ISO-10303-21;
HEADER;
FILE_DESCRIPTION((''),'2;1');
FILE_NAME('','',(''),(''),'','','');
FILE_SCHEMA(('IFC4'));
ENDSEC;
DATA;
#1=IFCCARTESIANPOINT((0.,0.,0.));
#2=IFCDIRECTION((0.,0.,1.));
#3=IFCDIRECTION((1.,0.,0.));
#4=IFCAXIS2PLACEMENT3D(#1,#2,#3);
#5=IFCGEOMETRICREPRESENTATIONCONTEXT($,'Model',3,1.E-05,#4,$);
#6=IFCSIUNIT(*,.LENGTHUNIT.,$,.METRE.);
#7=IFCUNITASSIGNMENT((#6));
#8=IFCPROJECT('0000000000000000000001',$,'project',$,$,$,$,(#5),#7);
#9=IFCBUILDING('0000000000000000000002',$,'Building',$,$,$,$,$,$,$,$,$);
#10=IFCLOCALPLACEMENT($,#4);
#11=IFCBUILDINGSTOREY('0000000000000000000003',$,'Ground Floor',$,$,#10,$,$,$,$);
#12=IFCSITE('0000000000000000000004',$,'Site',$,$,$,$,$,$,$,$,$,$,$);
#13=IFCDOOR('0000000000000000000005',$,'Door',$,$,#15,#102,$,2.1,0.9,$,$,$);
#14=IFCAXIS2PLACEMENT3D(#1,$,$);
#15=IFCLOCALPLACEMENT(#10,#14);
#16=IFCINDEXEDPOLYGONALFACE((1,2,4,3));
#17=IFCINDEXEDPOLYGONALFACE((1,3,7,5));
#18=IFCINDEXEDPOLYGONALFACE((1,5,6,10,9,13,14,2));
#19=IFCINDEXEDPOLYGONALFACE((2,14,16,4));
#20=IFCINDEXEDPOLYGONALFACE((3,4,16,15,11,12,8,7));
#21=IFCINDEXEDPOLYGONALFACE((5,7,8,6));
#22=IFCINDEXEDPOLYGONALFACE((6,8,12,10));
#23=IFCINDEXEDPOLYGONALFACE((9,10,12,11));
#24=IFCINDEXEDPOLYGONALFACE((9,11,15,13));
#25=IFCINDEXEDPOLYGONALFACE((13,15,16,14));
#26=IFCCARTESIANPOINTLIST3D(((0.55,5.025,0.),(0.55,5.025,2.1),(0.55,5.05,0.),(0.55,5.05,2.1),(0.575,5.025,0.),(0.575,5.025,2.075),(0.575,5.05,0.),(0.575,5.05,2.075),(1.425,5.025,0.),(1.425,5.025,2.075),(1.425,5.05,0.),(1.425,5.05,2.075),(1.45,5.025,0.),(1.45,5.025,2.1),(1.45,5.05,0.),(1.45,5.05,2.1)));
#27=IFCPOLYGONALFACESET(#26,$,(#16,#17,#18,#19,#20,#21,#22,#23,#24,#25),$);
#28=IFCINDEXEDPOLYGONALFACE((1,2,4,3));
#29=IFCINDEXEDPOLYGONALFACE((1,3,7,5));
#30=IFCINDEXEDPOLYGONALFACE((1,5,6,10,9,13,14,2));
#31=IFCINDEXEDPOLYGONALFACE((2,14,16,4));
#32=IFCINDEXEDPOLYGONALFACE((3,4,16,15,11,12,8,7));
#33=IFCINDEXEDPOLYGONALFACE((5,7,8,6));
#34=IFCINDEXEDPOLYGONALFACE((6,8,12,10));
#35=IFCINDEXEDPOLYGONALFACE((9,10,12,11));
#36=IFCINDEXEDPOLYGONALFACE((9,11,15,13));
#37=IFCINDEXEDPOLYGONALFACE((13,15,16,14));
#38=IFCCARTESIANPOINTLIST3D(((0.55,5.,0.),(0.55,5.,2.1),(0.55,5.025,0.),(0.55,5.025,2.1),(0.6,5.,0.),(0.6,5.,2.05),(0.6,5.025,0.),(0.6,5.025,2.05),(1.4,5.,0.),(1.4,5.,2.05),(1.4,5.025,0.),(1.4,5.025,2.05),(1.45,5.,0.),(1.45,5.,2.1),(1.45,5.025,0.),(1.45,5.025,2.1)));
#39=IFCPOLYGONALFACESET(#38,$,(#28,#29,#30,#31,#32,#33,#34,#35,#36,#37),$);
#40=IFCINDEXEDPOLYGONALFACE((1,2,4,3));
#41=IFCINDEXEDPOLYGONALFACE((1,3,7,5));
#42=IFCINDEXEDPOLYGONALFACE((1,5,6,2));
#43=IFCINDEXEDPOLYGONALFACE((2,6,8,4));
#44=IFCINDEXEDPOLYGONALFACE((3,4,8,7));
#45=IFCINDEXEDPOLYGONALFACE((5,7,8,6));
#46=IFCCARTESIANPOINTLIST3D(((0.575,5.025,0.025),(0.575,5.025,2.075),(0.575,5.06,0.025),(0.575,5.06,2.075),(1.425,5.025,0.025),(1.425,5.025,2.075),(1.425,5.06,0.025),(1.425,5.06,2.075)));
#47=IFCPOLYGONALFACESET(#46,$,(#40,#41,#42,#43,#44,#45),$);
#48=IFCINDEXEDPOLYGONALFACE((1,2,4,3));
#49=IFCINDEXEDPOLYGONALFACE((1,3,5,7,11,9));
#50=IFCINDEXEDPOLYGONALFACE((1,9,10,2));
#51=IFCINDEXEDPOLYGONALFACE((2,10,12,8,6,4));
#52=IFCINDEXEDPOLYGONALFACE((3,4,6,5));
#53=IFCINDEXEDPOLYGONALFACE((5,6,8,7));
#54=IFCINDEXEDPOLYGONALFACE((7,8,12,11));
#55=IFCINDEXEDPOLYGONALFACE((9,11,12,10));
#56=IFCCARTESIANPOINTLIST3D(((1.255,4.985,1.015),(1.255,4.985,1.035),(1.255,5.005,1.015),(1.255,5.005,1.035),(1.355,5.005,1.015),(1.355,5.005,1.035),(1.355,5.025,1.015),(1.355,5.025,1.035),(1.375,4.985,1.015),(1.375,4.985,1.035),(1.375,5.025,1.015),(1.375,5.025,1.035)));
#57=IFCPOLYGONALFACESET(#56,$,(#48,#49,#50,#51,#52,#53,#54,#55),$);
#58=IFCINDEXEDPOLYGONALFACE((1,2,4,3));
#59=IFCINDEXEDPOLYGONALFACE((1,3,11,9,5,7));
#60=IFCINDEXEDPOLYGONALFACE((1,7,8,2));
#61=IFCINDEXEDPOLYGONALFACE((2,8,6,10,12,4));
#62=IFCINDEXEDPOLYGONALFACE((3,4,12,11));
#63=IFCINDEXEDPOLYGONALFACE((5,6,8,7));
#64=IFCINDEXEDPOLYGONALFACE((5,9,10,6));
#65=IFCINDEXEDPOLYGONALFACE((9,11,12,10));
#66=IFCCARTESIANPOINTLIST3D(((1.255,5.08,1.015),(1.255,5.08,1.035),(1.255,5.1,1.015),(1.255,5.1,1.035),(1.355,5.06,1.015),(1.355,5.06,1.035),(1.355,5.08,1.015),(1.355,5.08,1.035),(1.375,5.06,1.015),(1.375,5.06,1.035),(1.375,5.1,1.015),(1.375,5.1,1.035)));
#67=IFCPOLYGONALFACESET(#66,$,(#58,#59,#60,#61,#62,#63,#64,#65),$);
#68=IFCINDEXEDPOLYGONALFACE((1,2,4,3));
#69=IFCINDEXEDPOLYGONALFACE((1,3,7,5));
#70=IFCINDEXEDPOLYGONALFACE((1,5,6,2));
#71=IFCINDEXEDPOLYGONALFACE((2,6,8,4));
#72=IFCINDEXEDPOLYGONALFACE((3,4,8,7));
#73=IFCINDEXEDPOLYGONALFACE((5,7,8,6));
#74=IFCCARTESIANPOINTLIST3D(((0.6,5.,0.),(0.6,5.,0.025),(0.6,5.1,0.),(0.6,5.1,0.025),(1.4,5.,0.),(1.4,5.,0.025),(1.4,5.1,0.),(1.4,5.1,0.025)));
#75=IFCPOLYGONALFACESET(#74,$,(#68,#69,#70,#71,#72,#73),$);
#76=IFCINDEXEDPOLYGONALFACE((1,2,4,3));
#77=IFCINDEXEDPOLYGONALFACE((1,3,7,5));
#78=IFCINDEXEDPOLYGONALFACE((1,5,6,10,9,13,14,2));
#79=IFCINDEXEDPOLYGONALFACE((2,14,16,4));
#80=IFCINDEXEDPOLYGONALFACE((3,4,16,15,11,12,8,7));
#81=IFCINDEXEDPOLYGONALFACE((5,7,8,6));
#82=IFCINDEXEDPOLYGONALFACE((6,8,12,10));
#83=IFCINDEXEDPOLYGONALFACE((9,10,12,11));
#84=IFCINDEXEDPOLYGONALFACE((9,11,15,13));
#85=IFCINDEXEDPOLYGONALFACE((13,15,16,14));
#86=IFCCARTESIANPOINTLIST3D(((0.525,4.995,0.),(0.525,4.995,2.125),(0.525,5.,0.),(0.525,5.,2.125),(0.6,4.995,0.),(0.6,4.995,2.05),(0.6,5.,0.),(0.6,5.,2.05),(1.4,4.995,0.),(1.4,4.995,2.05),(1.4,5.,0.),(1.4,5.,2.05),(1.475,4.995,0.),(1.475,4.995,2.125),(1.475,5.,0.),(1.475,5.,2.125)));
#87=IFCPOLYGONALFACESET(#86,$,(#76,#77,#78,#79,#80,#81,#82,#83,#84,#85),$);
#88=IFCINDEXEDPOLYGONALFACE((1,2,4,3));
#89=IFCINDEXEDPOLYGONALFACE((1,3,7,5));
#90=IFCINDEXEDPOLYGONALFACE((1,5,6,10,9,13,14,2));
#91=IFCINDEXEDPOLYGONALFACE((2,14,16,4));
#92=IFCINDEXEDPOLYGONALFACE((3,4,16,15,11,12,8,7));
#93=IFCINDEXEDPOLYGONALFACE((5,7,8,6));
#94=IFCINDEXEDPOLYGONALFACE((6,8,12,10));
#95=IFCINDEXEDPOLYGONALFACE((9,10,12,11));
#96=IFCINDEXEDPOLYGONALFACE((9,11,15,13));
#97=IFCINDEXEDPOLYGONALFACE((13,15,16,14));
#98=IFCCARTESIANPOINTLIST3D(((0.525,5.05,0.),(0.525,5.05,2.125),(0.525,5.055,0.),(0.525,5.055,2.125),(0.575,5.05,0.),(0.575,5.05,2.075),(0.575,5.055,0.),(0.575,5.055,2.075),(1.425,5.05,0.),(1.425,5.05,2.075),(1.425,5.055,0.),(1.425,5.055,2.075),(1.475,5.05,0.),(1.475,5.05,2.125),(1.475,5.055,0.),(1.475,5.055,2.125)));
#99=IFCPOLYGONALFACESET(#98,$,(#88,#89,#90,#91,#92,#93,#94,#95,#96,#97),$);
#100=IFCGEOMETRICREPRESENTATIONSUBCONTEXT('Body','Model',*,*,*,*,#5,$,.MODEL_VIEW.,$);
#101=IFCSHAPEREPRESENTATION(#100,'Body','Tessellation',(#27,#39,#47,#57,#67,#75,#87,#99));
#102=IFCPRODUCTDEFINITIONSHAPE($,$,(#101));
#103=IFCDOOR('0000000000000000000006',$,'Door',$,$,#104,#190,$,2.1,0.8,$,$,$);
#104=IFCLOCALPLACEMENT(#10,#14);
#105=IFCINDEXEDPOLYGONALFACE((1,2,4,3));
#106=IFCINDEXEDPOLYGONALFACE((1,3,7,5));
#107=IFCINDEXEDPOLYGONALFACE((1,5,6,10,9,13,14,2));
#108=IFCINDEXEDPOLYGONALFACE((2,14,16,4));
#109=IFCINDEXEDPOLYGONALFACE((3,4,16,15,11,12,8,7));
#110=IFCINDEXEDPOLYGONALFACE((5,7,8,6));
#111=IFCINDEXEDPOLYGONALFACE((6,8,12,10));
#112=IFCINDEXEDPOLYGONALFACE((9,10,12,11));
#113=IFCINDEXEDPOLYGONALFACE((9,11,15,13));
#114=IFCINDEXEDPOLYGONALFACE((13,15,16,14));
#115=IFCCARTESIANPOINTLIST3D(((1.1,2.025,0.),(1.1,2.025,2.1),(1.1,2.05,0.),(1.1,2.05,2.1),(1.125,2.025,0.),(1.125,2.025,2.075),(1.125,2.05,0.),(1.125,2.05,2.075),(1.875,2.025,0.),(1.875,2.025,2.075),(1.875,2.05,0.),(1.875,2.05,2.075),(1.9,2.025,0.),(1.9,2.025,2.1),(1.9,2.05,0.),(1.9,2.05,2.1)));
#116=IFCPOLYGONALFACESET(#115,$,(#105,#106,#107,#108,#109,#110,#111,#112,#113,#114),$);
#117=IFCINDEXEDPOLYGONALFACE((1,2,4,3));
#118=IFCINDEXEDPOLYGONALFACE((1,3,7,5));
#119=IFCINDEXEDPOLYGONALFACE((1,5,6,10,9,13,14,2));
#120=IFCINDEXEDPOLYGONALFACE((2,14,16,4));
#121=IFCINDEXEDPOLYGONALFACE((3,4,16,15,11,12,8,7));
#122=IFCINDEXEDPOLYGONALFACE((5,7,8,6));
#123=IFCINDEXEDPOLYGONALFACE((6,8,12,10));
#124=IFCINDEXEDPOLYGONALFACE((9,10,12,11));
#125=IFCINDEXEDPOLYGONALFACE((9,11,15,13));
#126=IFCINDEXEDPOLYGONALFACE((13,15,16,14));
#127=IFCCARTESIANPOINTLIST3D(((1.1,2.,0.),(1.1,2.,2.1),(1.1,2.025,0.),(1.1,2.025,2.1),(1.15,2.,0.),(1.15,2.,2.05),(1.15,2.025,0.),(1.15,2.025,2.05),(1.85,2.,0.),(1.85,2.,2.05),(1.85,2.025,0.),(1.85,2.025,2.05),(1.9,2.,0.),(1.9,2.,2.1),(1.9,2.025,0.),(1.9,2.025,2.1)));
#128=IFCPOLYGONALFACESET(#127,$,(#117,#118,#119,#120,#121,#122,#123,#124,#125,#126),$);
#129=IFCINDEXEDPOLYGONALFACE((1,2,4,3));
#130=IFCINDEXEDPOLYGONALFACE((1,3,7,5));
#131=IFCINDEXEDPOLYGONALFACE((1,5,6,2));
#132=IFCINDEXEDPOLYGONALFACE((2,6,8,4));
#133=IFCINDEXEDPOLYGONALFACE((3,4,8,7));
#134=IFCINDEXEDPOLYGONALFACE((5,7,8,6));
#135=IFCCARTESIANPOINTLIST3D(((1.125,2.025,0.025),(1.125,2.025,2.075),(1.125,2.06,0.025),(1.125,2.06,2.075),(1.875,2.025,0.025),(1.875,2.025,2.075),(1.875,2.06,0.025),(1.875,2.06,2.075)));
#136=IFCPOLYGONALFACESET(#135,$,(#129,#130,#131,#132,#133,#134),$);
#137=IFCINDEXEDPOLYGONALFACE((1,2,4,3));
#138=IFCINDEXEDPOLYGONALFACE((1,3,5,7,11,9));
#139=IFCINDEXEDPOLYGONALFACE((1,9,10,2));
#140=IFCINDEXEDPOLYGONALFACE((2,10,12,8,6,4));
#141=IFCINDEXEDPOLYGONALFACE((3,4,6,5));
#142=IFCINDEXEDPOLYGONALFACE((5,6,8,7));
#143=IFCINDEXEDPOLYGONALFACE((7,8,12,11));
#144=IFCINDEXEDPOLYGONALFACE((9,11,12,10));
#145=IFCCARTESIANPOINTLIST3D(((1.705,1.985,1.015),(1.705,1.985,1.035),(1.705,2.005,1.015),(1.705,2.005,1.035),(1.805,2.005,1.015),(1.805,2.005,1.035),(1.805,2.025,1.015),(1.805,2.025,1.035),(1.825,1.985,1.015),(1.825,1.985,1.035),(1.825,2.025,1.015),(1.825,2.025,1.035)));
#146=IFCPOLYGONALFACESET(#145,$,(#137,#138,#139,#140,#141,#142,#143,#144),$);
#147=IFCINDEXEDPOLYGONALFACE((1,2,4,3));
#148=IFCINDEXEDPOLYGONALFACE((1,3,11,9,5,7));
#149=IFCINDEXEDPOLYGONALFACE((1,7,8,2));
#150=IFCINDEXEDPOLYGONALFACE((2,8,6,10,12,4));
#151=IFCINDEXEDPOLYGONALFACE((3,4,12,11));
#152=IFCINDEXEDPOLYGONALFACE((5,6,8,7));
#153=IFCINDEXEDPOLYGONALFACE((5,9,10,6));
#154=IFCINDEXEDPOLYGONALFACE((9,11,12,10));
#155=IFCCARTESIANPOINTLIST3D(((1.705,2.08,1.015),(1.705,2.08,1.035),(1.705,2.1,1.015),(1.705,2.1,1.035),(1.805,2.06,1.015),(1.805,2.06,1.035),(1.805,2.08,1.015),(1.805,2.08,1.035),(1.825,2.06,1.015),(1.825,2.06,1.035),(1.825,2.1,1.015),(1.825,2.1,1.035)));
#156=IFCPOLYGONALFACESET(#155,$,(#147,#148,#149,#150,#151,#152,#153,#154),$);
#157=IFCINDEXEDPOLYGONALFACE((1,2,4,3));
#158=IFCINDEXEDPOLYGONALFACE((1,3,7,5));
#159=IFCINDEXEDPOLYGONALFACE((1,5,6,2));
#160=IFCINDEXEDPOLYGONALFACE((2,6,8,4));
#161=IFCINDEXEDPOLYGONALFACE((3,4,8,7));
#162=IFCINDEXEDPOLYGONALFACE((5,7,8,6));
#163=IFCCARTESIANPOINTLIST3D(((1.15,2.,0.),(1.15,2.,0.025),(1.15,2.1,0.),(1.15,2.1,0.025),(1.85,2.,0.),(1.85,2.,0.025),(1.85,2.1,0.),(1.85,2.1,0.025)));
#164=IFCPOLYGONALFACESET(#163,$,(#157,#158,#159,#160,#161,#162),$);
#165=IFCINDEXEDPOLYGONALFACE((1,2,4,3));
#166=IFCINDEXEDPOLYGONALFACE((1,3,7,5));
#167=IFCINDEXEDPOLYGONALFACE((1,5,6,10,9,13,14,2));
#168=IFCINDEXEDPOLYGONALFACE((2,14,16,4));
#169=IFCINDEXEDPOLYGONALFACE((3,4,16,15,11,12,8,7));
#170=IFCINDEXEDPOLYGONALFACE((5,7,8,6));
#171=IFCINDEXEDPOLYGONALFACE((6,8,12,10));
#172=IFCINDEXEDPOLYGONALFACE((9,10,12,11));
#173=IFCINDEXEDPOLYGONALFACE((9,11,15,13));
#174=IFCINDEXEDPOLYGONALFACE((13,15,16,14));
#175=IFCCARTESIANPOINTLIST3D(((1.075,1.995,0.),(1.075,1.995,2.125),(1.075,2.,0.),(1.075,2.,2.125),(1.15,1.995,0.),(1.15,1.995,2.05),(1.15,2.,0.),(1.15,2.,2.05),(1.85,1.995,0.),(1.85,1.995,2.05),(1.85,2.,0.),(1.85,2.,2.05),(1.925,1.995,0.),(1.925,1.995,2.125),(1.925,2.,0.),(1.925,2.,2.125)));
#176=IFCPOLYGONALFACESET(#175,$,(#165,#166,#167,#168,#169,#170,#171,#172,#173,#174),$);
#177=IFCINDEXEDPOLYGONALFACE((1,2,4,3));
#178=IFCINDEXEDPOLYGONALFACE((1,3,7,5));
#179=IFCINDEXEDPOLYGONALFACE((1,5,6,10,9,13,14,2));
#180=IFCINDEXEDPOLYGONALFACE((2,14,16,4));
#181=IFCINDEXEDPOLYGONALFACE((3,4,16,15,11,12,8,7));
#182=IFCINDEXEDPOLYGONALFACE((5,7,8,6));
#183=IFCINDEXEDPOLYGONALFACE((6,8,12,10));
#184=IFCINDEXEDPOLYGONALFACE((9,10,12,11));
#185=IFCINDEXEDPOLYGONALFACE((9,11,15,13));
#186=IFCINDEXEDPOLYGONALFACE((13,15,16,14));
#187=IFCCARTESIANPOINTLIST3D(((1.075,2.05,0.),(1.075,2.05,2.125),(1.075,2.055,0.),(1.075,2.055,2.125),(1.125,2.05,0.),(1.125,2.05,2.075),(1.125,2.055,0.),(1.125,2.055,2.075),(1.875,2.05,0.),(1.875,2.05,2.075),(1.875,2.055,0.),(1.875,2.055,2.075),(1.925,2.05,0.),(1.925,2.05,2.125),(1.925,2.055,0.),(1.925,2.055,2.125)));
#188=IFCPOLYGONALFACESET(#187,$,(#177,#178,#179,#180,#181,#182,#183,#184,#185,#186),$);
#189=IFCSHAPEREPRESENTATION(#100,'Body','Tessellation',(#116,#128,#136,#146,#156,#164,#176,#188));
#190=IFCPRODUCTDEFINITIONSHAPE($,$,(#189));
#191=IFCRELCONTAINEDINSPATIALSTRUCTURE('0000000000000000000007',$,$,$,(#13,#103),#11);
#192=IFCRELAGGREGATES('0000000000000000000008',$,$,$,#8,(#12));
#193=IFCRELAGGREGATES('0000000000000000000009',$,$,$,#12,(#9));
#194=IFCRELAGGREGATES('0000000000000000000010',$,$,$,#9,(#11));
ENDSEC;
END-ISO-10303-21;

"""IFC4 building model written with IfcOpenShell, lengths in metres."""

from ifc_helpers import new_model, si_unit, frame, origin_with_axes, place, context, subcontext, project, spatial, line, indexed_curve, outline, extrude, element, save


model = new_model("IFC4")

# Units and contexts
model_context = context("Model", 3, precision=1e-05, world=origin_with_axes())
body_context = subcontext(model_context, "Body", "Model", "MODEL_VIEW")
ifc_project = project(units=[si_unit("LENGTHUNIT", "METRE")], contexts=[model_context])

# Site, building, storey
site = spatial("IfcSite", under=ifc_project, Name="Site")
building = spatial("IfcBuilding", under=site, Name="Building")
storey_placement = place(None, origin_with_axes())
storey = spatial("IfcBuildingStorey", under=building, at=storey_placement, Name="Ground Floor")

# Doors
door_1_placement = place(storey_placement, frame((0.55, 5.0, 0.0), z_axis=(0.0, 0.0, 1.0), x_axis=(1.0, 0.0, 0.0)))
element("IfcDoor", 1, at=door_1_placement, inside=storey, Name="Door", OverallHeight=2.1, OverallWidth=0.9, context=body_context, shape_type="SweptSolid", body=[
    extrude(outline(indexed_curve([(0.0, 0.0), (0.0, 2.1), (0.9, 2.1), (0.9, 0.0), (0.875, 0.0), (0.875, 2.075), (0.025, 2.075), (0.025, 0.0)], segments=[line(1, 2, 3, 4, 5, 6, 7, 8, 1)])), frame((0.0, 0.025, 0.0), z_axis=(0.0, -1.0, 0.0), x_axis=(1.0, 0.0, 0.0)), (0.0, 0.0, -1.0), 0.025),
    extrude(outline(indexed_curve([(0.0, 0.0), (0.0, 2.1), (0.9, 2.1), (0.9, 0.0), (0.85, 0.0), (0.85, 2.05), (0.05, 2.05), (0.05, 0.0)], segments=[line(1, 2, 3, 4, 5, 6, 7, 8, 1)])), frame((0.0, 0.0, 0.0), z_axis=(0.0, -1.0, 0.0), x_axis=(1.0, 0.0, 0.0)), (0.0, 0.0, -1.0), 0.025),
    extrude(outline(indexed_curve([(0.0, 0.0), (0.85, 0.0), (0.85, 0.035), (0.0, 0.035)], segments=[line(1, 2, 3, 4, 1)])), frame((0.025, 0.025, 0.025), z_axis=(0.0, 0.0, 1.0), x_axis=(1.0, 0.0, 0.0)), (0.0, 0.0, 1.0), 2.05),
    extrude(outline(indexed_curve([(0.0, 0.0), (0.0, -0.04), (-0.12, -0.04), (-0.12, -0.02), (-0.02, -0.02), (-0.02, 0.0)], segments=[line(1, 2, 3, 4, 5, 6, 1)])), frame((0.825, 0.025, 1.015), z_axis=(0.0, 0.0, 1.0), x_axis=(1.0, 0.0, 0.0)), (0.0, 0.0, 1.0), 0.02),
    extrude(outline(indexed_curve([(0.0, 0.0), (0.0, 0.04), (-0.12, 0.04), (-0.12, 0.02), (-0.02, 0.02), (-0.02, 0.0)], segments=[line(1, 2, 3, 4, 5, 6, 1)])), frame((0.825, 0.06, 1.015), z_axis=(0.0, 0.0, 1.0), x_axis=(1.0, 0.0, 0.0)), (0.0, 0.0, 1.0), 0.02),
    extrude(outline(indexed_curve([(0.0, 0.0), (0.8, 0.0), (0.8, 0.1), (0.0, 0.1)], segments=[line(1, 2, 3, 4, 1)])), frame((0.05, 0.0, 0.0), z_axis=(0.0, 0.0, 1.0), x_axis=(1.0, 0.0, 0.0)), (0.0, 0.0, 1.0), 0.025),
    extrude(outline(indexed_curve([(0.0, 0.0), (0.0, 2.125), (0.95, 2.125), (0.95, 0.0), (0.875, 0.0), (0.875, 2.05), (0.075, 2.05), (0.075, 0.0)], segments=[line(1, 2, 3, 4, 5, 6, 7, 8, 1)])), frame((-0.025, -0.005, 0.0), z_axis=(0.0, -1.0, 0.0), x_axis=(1.0, 0.0, 0.0)), (0.0, 0.0, -1.0), 0.005),
    extrude(outline(indexed_curve([(0.0, 0.0), (0.0, 2.125), (0.95, 2.125), (0.95, 0.0), (0.9, 0.0), (0.9, 2.075), (0.05, 2.075), (0.05, 0.0)], segments=[line(1, 2, 3, 4, 5, 6, 7, 8, 1)])), frame((-0.025, 0.05, 0.0), z_axis=(0.0, -1.0, 0.0), x_axis=(1.0, 0.0, 0.0)), (0.0, 0.0, -1.0), 0.005),
])
door_2_placement = place(storey_placement, frame((1.1, 2.0, 0.0), z_axis=(0.0, 0.0, 1.0), x_axis=(1.0, 0.0, 0.0)))
element("IfcDoor", 2, at=door_2_placement, inside=storey, Name="Door", OverallHeight=2.1, OverallWidth=0.8, context=body_context, shape_type="SweptSolid", body=[
    extrude(outline(indexed_curve([(0.0, 0.0), (0.0, 2.1), (0.8, 2.1), (0.8, 0.0), (0.775, 0.0), (0.775, 2.075), (0.025, 2.075), (0.025, 0.0)], segments=[line(1, 2, 3, 4, 5, 6, 7, 8, 1)])), frame((0.0, 0.025, 0.0), z_axis=(0.0, -1.0, 0.0), x_axis=(1.0, 0.0, 0.0)), (0.0, 0.0, -1.0), 0.025),
    extrude(outline(indexed_curve([(0.0, 0.0), (0.0, 2.1), (0.8, 2.1), (0.8, 0.0), (0.75, 0.0), (0.75, 2.05), (0.05, 2.05), (0.05, 0.0)], segments=[line(1, 2, 3, 4, 5, 6, 7, 8, 1)])), frame((0.0, 0.0, 0.0), z_axis=(0.0, -1.0, 0.0), x_axis=(1.0, 0.0, 0.0)), (0.0, 0.0, -1.0), 0.025),
    extrude(outline(indexed_curve([(0.0, 0.0), (0.75, 0.0), (0.75, 0.035), (0.0, 0.035)], segments=[line(1, 2, 3, 4, 1)])), frame((0.025, 0.025, 0.025), z_axis=(0.0, 0.0, 1.0), x_axis=(1.0, 0.0, 0.0)), (0.0, 0.0, 1.0), 2.05),
    extrude(outline(indexed_curve([(0.0, 0.0), (0.0, -0.04), (-0.12, -0.04), (-0.12, -0.02), (-0.02, -0.02), (-0.02, 0.0)], segments=[line(1, 2, 3, 4, 5, 6, 1)])), frame((0.725, 0.025, 1.015), z_axis=(0.0, 0.0, 1.0), x_axis=(1.0, 0.0, 0.0)), (0.0, 0.0, 1.0), 0.02),
    extrude(outline(indexed_curve([(0.0, 0.0), (0.0, 0.04), (-0.12, 0.04), (-0.12, 0.02), (-0.02, 0.02), (-0.02, 0.0)], segments=[line(1, 2, 3, 4, 5, 6, 1)])), frame((0.725, 0.06, 1.015), z_axis=(0.0, 0.0, 1.0), x_axis=(1.0, 0.0, 0.0)), (0.0, 0.0, 1.0), 0.02),
    extrude(outline(indexed_curve([(0.0, 0.0), (0.7, 0.0), (0.7, 0.1), (0.0, 0.1)], segments=[line(1, 2, 3, 4, 1)])), frame((0.05, 0.0, 0.0), z_axis=(0.0, 0.0, 1.0), x_axis=(1.0, 0.0, 0.0)), (0.0, 0.0, 1.0), 0.025),
    extrude(outline(indexed_curve([(0.0, 0.0), (0.0, 2.125), (0.85, 2.125), (0.85, 0.0), (0.775, 0.0), (0.775, 2.05), (0.075, 2.05), (0.075, 0.0)], segments=[line(1, 2, 3, 4, 5, 6, 7, 8, 1)])), frame((-0.025, -0.005, 0.0), z_axis=(0.0, -1.0, 0.0), x_axis=(1.0, 0.0, 0.0)), (0.0, 0.0, -1.0), 0.005),
    extrude(outline(indexed_curve([(0.0, 0.0), (0.0, 2.125), (0.85, 2.125), (0.85, 0.0), (0.8, 0.0), (0.8, 2.075), (0.05, 2.075), (0.05, 0.0)], segments=[line(1, 2, 3, 4, 5, 6, 7, 8, 1)])), frame((-0.025, 0.05, 0.0), z_axis=(0.0, -1.0, 0.0), x_axis=(1.0, 0.0, 0.0)), (0.0, 0.0, -1.0), 0.005),
])

save(model, "model.ifc")
